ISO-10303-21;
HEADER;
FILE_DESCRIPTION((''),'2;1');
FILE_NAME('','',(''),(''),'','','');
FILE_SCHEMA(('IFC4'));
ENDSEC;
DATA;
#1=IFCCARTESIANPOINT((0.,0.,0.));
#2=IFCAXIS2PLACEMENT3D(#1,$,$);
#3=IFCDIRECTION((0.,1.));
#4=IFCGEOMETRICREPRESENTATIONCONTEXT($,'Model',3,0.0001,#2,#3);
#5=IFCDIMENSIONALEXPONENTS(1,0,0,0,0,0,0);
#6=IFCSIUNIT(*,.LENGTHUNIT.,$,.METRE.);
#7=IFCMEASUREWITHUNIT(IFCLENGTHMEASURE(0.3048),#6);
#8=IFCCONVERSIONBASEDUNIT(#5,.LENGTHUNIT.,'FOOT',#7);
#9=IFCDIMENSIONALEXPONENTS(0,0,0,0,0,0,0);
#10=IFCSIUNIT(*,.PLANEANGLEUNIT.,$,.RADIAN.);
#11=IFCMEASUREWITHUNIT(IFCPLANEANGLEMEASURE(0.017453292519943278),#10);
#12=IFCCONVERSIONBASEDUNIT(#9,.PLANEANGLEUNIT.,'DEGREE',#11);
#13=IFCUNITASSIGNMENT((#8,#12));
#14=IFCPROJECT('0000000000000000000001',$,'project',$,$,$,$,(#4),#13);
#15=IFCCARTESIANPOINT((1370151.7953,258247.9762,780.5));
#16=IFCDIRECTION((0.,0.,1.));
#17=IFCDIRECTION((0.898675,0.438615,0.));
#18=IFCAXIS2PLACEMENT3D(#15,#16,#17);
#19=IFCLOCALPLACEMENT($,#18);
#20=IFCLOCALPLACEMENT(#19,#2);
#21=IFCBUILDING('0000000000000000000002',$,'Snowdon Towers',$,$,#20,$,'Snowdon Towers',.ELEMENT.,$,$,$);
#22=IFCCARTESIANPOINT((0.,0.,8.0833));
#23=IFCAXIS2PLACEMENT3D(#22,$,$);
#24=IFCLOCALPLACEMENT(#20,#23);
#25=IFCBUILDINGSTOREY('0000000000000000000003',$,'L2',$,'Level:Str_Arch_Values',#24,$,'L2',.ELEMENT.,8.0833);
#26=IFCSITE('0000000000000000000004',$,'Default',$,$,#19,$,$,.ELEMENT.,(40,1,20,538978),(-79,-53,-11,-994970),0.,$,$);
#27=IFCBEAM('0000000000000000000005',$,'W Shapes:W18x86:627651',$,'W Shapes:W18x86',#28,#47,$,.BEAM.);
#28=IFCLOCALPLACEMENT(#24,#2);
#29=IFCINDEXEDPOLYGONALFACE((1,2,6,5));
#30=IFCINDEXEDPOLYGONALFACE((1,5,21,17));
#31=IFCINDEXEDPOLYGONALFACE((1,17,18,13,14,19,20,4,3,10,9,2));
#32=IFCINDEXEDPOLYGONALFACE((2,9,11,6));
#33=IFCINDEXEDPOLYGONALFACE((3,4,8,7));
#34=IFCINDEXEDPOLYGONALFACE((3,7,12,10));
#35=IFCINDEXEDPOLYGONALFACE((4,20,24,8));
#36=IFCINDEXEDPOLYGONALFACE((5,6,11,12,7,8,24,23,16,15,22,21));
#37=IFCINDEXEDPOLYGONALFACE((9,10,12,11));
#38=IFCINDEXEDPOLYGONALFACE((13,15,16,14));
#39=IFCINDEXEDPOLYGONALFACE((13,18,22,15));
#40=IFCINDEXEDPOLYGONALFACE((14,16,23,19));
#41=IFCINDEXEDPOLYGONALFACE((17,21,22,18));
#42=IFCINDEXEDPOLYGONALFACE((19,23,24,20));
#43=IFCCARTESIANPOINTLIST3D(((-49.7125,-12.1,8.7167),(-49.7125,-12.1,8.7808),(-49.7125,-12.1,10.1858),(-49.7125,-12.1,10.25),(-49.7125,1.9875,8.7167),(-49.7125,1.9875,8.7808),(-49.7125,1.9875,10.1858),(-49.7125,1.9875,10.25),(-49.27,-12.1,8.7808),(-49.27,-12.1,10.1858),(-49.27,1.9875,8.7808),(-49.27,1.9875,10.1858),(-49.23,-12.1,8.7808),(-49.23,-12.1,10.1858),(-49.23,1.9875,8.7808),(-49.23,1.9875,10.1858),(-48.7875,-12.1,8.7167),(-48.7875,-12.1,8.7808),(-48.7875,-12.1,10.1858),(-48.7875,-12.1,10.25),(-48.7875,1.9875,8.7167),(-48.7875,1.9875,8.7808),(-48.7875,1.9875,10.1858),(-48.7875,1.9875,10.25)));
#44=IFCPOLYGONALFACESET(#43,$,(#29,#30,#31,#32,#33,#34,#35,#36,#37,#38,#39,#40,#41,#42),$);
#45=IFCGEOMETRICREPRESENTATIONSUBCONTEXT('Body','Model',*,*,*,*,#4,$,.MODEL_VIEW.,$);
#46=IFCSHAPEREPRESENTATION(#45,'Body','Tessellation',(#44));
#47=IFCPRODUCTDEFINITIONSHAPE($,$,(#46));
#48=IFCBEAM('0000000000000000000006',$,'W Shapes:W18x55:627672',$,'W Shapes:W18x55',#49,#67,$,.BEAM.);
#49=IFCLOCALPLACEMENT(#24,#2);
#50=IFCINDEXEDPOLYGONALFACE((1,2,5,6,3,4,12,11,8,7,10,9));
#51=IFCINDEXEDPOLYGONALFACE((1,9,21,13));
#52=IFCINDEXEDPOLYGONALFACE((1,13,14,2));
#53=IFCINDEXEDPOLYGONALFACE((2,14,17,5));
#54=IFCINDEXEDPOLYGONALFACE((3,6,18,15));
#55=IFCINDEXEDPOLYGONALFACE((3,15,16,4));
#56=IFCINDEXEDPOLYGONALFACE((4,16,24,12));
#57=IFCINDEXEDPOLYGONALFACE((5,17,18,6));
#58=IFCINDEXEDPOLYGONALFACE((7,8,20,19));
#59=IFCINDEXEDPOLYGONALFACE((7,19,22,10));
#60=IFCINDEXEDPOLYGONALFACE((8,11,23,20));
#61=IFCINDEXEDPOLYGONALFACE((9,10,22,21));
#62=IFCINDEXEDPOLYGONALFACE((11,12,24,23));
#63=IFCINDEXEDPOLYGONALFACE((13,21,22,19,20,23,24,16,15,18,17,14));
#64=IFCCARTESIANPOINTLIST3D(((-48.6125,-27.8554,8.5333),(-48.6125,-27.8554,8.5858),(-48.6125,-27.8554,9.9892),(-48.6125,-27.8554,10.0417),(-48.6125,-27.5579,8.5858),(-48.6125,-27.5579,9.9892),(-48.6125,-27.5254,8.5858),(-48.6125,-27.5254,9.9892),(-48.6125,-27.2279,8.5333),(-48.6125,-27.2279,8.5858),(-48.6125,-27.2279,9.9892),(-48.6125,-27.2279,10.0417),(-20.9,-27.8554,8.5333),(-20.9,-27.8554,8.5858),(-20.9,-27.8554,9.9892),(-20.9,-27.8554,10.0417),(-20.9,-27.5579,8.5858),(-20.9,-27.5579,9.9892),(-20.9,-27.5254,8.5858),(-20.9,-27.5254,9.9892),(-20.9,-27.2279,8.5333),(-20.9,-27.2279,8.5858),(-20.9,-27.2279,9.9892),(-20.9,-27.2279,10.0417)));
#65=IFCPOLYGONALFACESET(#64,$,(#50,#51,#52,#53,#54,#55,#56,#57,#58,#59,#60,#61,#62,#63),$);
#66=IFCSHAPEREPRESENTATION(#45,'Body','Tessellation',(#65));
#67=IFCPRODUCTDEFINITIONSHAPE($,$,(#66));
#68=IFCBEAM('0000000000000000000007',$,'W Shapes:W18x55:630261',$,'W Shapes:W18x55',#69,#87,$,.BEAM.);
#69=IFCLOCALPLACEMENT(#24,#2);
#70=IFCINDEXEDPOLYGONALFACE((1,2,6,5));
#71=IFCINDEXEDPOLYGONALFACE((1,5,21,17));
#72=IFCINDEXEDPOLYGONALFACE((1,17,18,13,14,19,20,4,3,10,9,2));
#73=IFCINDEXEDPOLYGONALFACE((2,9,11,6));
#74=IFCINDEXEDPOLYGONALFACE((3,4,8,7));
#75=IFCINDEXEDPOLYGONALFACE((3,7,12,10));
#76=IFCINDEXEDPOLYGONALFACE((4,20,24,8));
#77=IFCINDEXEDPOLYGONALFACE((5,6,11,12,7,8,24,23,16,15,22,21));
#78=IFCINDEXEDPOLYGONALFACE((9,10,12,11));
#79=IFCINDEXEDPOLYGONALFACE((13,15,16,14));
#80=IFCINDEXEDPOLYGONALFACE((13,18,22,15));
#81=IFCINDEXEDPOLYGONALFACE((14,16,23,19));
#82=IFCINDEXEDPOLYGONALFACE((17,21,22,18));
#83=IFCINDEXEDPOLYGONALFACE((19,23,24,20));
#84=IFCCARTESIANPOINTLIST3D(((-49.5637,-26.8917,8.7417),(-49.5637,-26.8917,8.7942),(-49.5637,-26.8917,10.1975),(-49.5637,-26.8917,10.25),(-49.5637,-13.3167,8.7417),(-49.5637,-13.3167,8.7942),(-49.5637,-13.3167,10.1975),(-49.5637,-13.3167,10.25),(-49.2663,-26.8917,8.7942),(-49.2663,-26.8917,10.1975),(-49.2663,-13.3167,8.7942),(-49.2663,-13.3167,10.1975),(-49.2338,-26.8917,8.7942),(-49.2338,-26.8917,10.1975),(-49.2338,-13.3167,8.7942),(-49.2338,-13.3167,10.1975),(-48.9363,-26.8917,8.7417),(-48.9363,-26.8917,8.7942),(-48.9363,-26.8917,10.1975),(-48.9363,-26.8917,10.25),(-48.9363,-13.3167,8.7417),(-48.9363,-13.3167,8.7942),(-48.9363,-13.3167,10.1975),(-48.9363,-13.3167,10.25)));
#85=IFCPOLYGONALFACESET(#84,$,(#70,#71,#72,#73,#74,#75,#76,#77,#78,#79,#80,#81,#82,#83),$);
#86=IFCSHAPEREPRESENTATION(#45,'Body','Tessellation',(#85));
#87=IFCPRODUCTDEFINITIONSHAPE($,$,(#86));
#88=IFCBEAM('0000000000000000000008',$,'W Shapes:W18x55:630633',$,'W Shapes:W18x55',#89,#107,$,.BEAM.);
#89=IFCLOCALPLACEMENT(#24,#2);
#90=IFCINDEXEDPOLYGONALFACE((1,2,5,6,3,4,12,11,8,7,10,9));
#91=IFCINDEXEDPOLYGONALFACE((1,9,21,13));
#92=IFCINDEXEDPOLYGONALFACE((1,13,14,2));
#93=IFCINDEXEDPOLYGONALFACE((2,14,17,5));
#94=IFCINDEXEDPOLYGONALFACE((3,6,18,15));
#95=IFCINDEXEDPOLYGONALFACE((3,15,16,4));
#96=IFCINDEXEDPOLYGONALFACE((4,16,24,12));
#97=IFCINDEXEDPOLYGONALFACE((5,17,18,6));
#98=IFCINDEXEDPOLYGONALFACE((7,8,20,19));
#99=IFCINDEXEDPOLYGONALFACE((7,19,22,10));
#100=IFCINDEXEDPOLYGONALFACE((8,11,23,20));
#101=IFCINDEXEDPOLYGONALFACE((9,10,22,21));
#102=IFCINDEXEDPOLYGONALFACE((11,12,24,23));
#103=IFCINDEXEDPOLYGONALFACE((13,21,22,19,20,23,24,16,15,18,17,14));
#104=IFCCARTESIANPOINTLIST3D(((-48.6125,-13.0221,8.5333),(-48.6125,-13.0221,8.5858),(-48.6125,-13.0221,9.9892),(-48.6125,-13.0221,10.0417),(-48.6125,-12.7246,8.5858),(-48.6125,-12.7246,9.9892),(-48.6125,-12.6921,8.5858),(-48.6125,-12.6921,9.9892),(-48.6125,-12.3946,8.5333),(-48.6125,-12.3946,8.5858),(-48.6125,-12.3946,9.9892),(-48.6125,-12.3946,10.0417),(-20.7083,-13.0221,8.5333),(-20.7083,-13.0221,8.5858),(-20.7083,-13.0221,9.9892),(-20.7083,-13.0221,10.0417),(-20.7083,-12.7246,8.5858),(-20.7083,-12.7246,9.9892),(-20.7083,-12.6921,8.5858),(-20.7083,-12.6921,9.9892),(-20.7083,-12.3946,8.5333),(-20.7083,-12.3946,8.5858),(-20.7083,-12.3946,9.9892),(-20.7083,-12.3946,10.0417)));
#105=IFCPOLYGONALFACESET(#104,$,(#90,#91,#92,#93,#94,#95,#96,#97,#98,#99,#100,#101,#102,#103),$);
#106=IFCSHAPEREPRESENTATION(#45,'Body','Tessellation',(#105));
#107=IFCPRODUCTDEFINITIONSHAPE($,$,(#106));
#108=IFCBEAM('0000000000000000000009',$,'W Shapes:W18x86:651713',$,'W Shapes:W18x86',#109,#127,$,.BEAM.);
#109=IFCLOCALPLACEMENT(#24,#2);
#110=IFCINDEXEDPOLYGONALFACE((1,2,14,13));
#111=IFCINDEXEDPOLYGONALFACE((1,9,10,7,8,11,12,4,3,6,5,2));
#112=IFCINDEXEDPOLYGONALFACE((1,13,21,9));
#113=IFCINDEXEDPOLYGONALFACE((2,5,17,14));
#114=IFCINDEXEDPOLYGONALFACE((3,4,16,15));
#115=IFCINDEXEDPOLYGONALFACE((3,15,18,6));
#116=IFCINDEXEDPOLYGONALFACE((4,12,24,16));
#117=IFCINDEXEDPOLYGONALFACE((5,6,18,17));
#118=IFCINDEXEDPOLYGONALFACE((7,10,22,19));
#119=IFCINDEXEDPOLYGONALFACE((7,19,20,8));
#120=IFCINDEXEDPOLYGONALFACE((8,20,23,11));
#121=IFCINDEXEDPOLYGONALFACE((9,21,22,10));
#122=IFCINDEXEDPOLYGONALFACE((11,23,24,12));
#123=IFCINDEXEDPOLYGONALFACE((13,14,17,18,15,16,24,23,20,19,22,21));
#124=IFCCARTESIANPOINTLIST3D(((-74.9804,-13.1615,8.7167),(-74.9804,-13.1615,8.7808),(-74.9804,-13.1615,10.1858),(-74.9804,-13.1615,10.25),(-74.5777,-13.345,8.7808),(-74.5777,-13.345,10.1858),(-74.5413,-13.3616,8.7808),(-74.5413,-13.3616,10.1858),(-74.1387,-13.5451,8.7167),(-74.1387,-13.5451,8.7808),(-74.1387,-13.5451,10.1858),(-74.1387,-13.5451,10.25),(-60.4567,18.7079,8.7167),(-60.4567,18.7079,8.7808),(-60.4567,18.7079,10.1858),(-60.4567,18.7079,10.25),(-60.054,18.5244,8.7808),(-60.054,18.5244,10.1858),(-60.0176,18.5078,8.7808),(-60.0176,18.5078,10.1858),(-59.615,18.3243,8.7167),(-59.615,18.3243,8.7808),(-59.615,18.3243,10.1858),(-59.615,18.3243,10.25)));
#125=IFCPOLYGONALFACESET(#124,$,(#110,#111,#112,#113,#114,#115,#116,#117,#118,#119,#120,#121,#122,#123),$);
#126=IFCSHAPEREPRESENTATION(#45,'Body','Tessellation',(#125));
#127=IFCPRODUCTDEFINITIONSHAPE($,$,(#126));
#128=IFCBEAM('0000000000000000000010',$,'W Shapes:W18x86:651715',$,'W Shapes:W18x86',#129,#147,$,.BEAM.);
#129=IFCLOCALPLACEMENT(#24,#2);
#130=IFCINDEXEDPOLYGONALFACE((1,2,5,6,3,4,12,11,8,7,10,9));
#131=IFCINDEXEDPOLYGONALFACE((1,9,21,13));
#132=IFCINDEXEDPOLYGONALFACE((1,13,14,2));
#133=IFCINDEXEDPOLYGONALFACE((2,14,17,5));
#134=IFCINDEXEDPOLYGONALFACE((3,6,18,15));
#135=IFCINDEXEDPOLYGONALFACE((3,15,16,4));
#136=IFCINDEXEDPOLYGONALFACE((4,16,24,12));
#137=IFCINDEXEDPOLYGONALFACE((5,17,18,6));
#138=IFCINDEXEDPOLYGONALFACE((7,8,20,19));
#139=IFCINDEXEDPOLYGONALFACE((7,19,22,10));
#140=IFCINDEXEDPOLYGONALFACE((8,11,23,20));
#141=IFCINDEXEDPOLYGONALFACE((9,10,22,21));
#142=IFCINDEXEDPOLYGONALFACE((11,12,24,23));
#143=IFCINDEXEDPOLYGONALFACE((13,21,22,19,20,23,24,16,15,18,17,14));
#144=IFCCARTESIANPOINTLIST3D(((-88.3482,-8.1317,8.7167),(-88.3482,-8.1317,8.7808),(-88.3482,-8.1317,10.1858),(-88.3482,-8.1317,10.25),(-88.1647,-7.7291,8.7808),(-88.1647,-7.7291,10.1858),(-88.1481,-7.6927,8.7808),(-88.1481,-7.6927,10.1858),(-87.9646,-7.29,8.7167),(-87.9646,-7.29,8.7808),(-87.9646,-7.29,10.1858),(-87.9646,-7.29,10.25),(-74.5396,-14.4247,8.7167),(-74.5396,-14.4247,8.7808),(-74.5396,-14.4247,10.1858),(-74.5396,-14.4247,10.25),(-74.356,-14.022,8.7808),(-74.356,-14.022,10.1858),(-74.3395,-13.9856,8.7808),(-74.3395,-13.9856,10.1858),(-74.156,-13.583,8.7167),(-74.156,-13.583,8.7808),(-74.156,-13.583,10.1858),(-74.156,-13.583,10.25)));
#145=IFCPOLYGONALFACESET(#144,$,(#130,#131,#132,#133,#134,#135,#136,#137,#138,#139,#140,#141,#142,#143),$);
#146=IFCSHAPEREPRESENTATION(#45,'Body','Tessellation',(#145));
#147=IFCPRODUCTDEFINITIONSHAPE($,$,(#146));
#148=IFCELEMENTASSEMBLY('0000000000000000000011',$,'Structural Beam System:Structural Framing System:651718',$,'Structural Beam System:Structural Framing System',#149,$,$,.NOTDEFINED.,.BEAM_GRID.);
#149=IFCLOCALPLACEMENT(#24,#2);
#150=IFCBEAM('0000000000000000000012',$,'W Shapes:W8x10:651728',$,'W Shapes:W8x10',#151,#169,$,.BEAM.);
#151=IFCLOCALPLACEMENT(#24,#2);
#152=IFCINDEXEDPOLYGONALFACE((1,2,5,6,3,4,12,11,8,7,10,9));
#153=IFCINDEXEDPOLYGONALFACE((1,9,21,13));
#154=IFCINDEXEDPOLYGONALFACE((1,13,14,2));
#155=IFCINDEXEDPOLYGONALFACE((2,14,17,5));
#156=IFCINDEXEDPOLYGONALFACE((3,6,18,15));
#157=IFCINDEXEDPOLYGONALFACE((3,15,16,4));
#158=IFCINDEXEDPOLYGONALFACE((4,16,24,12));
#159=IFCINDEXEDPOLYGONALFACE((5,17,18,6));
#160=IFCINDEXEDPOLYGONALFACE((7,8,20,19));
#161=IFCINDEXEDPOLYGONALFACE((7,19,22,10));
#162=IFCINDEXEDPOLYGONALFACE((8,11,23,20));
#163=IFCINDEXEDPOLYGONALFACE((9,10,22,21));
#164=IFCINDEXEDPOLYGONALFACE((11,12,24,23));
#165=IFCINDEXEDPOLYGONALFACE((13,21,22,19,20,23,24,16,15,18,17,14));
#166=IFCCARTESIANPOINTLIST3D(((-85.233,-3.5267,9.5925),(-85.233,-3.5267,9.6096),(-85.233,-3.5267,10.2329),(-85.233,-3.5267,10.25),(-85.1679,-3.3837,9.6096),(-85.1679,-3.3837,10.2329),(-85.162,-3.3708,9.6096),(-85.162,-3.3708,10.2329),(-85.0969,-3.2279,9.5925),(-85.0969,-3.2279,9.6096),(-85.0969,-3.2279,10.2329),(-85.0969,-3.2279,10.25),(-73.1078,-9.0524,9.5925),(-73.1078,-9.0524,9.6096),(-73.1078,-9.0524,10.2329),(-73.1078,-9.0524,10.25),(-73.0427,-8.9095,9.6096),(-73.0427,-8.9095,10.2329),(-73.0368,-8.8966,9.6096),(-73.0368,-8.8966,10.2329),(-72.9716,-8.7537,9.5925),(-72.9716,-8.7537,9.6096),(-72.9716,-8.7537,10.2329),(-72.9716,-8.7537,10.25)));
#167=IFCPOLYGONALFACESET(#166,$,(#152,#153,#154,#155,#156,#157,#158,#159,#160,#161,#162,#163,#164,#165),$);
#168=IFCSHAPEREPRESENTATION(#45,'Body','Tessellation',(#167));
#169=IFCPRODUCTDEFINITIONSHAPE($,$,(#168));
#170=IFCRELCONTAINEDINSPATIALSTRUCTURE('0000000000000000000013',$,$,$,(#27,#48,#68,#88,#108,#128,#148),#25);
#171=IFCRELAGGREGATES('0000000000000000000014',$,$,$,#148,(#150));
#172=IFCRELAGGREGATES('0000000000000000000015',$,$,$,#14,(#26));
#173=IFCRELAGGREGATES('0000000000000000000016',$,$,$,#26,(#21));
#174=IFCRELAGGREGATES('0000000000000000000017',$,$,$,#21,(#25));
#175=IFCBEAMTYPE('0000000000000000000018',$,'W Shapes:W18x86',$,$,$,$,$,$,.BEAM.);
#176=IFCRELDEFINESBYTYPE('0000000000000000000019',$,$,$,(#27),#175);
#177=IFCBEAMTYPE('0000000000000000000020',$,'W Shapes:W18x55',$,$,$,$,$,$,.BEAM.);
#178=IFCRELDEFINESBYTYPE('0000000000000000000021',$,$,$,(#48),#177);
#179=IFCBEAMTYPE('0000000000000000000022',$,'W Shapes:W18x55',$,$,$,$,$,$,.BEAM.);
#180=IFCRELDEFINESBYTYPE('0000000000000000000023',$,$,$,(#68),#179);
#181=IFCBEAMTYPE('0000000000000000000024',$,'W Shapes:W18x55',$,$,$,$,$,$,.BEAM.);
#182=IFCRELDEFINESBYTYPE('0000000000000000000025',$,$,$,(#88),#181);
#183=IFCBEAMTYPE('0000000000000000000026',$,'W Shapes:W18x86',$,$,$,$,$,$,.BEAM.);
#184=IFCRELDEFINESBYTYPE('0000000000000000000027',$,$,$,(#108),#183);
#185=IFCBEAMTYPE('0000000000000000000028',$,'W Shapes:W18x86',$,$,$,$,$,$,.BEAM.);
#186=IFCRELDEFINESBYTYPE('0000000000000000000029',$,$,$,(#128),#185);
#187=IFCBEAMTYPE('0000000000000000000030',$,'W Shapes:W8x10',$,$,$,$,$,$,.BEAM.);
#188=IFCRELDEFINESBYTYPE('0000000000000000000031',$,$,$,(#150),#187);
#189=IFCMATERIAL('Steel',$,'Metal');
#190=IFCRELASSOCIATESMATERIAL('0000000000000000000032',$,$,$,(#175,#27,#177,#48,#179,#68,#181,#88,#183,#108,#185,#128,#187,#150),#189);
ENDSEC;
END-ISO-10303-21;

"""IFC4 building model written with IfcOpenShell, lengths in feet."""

from ifc_helpers import new_model, entity, si_unit, converted_unit, direction, frame, origin, place, context, subcontext, project, spatial, indexed_curve, outline, extrude, source, transform, mapped, material, type_object, type_shapes, element, aggregate, save


model = new_model("IFC4")

# Units and contexts
model_context = context("Model", 3, precision=0.0001, world=origin(), true_north=direction((0.0, 1.0)))
body_context = subcontext(model_context, "Body", "Model", "MODEL_VIEW")
ifc_project = project(units=[converted_unit("LENGTHUNIT", "FOOT", entity("IfcLengthMeasure", 0.3048), si_unit("LENGTHUNIT", "METRE"), dimensions=[1, 0, 0, 0, 0, 0, 0]), converted_unit("PLANEANGLEUNIT", "DEGREE", entity("IfcPlaneAngleMeasure", 0.017453292519943278), si_unit("PLANEANGLEUNIT", "RADIAN"), dimensions=[0, 0, 0, 0, 0, 0, 0])], contexts=[model_context])

# Site, building, storey
site_placement = place(None, frame((1370151.7953, 258247.9762, 780.5), z_axis=(0.0, 0.0, 1.0), x_axis=(0.898675, 0.438615, 0.0)))
site = spatial("IfcSite", under=ifc_project, at=site_placement, Name="Default", CompositionType="ELEMENT", RefLatitude=(40, 1, 20, 538978), RefLongitude=(-79, -53, -11, -994970), RefElevation=0.0)
building_placement = place(site_placement, origin())
building = spatial("IfcBuilding", under=site, at=building_placement, Name="Snowdon Towers", LongName="Snowdon Towers", CompositionType="ELEMENT")
storey_placement = place(building_placement, frame((0.0, 0.0, 8.0833)))
storey = spatial("IfcBuildingStorey", under=building, at=storey_placement, Name="L2", ObjectType="Level:Str_Arch_Values", LongName="L2", CompositionType="ELEMENT", Elevation=8.0833)

# Beams
ifc_material = material(Name="Steel", Category="Metal")
beam_type_1 = type_object("IfcBeamType", Name="W Shapes:W18x86", PredefinedType="BEAM", material=ifc_material)
shared_shape_1 = source(origin(), body_context, "Body", "SweptSolid", [
    extrude(outline(indexed_curve([(-0.4625, -0.7025), (-0.4625, -0.7667), (0.4625, -0.7667), (0.4625, -0.7025), (0.02, -0.7025), (0.02, 0.7025), (0.4625, 0.7025), (0.4625, 0.7667), (-0.4625, 0.7667), (-0.4625, 0.7025), (-0.02, 0.7025), (-0.02, -0.7025), (-0.4625, -0.7025)], self_intersect=False)), frame((-7.0917, 0.0, 0.0), z_axis=(-1.0, 0.0, 0.0), x_axis=(0.0, -1.0, 0.0)), (0.0, 0.0, -1.0), 14.0875),
])
type_shapes(beam_type_1, [shared_shape_1])
beam_1_placement = place(storey_placement, frame((-49.25, -5.1042, 9.4833), z_axis=(0.0, 0.0, 1.0), x_axis=(0.0, -1.0, 0.0)))
element("IfcBeam", 1, at=beam_1_placement, inside=storey, type_object=beam_type_1, material=ifc_material, Name="W Shapes:W18x86:627651", ObjectType="W Shapes:W18x86", PredefinedType="BEAM", context=body_context, shape_type="MappedRepresentation", body=[
    mapped(shared_shape_1, transform((0.0, 0.0, 0.0), scale=1.0)),
])
beam_type_2 = type_object("IfcBeamType", Name="W Shapes:W18x55", PredefinedType="BEAM", material=ifc_material)
shared_shape_2 = source(origin(), body_context, "Body", "SweptSolid", [
    extrude(outline(indexed_curve([(-0.3138, -0.7017), (-0.3138, -0.7542), (0.3138, -0.7542), (0.3138, -0.7017), (0.0162, -0.7017), (0.0162, 0.7017), (0.3138, 0.7017), (0.3138, 0.7542), (-0.3137, 0.7542), (-0.3137, 0.7017), (-0.0163, 0.7017), (-0.0163, -0.7017), (-0.3138, -0.7017)], self_intersect=False)), frame((-13.8625, 0.0, 0.0), z_axis=(-1.0, 0.0, 0.0), x_axis=(0.0, -1.0, 0.0)), (0.0, 0.0, -1.0), 27.7125),
])
type_shapes(beam_type_2, [shared_shape_2])
beam_2_placement = place(storey_placement, frame((-34.75, -27.5417, 9.2875)))
element("IfcBeam", 2, at=beam_2_placement, inside=storey, type_object=beam_type_2, material=ifc_material, Name="W Shapes:W18x55:627672", ObjectType="W Shapes:W18x55", PredefinedType="BEAM", context=body_context, shape_type="MappedRepresentation", body=[
    mapped(shared_shape_2, transform((0.0, 0.0, 0.0), scale=1.0)),
])
beam_type_3 = type_object("IfcBeamType", Name="W Shapes:W18x55", PredefinedType="BEAM", material=ifc_material)
shared_shape_3 = source(origin(), body_context, "Body", "SweptSolid", [
    extrude(outline(indexed_curve([(-0.3138, -0.7017), (-0.3138, -0.7542), (0.3138, -0.7542), (0.3138, -0.7017), (0.0162, -0.7017), (0.0162, 0.7017), (0.3138, 0.7017), (0.3138, 0.7542), (-0.3137, 0.7542), (-0.3137, 0.7017), (-0.0163, 0.7017), (-0.0163, -0.7017), (-0.3138, -0.7017)], self_intersect=False)), frame((-7.0375, 0.0, 0.0), z_axis=(-1.0, 0.0, 0.0), x_axis=(0.0, -1.0, 0.0)), (0.0, 0.0, -1.0), 13.575),
])
type_shapes(beam_type_3, [shared_shape_3])
beam_3_placement = place(storey_placement, frame((-49.25, -20.3542, 9.4958), z_axis=(0.0, 0.0, 1.0), x_axis=(0.0, -1.0, 0.0)))
element("IfcBeam", 3, at=beam_3_placement, inside=storey, type_object=beam_type_3, material=ifc_material, Name="W Shapes:W18x55:630261", ObjectType="W Shapes:W18x55", PredefinedType="BEAM", context=body_context, shape_type="MappedRepresentation", body=[
    mapped(shared_shape_3, transform((0.0, 0.0, 0.0), scale=1.0)),
])
beam_type_4 = type_object("IfcBeamType", Name="W Shapes:W18x55", PredefinedType="BEAM", material=ifc_material)
shared_shape_4 = source(origin(), body_context, "Body", "SweptSolid", [
    extrude(outline(indexed_curve([(-0.3138, -0.7017), (-0.3138, -0.7542), (0.3138, -0.7542), (0.3138, -0.7017), (0.0162, -0.7017), (0.0162, 0.7017), (0.3138, 0.7017), (0.3138, 0.7542), (-0.3137, 0.7542), (-0.3137, 0.7017), (-0.0163, 0.7017), (-0.0163, -0.7017), (-0.3138, -0.7017)], self_intersect=False)), frame((-13.8625, 0.0, 0.0), z_axis=(-1.0, 0.0, 0.0), x_axis=(0.0, -1.0, 0.0)), (0.0, 0.0, -1.0), 27.9042),
])
type_shapes(beam_type_4, [shared_shape_4])
beam_4_placement = place(storey_placement, frame((-34.75, -12.7083, 9.2875)))
element("IfcBeam", 4, at=beam_4_placement, inside=storey, type_object=beam_type_4, material=ifc_material, Name="W Shapes:W18x55:630633", ObjectType="W Shapes:W18x55", PredefinedType="BEAM", context=body_context, shape_type="MappedRepresentation", body=[
    mapped(shared_shape_4, transform((0.0, 0.0, 0.0), scale=1.0)),
])

# Beams
beam_type_5 = type_object("IfcBeamType", Name="W Shapes:W18x86", PredefinedType="BEAM", material=ifc_material)
shared_shape_5 = source(origin(), body_context, "Body", "SweptSolid", [
    extrude(outline(indexed_curve([(-0.4625, -0.7025), (-0.4625, -0.7667), (0.4625, -0.7667), (0.4625, -0.7025), (0.02, -0.7025), (0.02, 0.7025), (0.4625, 0.7025), (0.4625, 0.7667), (-0.4625, 0.7667), (-0.4625, 0.7025), (-0.02, 0.7025), (-0.02, -0.7025), (-0.4625, -0.7025)], self_intersect=False)), frame((-17.6397, 0.0, 0.0), z_axis=(-1.0, 0.0, 0.0), x_axis=(0.0, -1.0, 0.0)), (0.0, 0.0, -1.0), 35.0228),
])
type_shapes(beam_type_5, [shared_shape_5])
beam_5_placement = place(storey_placement, frame((-67.2445, 2.6981, 9.4833), z_axis=(0.0, 0.0, 1.0), x_axis=(0.414693, 0.909961, 0.0)))
element("IfcBeam", 5, at=beam_5_placement, inside=storey, type_object=beam_type_5, material=ifc_material, Name="W Shapes:W18x86:651713", ObjectType="W Shapes:W18x86", PredefinedType="BEAM", context=body_context, shape_type="MappedRepresentation", body=[
    mapped(shared_shape_5, transform((0.0, 0.0, 0.0), scale=1.0)),
])
beam_type_6 = type_object("IfcBeamType", Name="W Shapes:W18x86", PredefinedType="BEAM", material=ifc_material)
shared_shape_6 = source(origin(), body_context, "Body", "SweptSolid", [
    extrude(outline(indexed_curve([(-0.4625, -0.7025), (-0.4625, -0.7667), (0.4625, -0.7667), (0.4625, -0.7025), (0.02, -0.7025), (0.02, 0.7025), (0.4625, 0.7025), (0.4625, 0.7667), (-0.4625, 0.7667), (-0.4625, 0.7025), (-0.02, 0.7025), (-0.02, -0.7025), (-0.4625, -0.7025)], self_intersect=False)), frame((-7.5875, 0.0, 0.0), z_axis=(-1.0, 0.0, 0.0), x_axis=(0.0, -1.0, 0.0)), (0.0, 0.0, -1.0), 15.175),
])
type_shapes(beam_type_6, [shared_shape_6])
beam_6_placement = place(storey_placement, frame((-81.2521, -10.8574, 9.4833), z_axis=(0.0, 0.0, 1.0), x_axis=(0.909961, -0.414693, 0.0)))
element("IfcBeam", 6, at=beam_6_placement, inside=storey, type_object=beam_type_6, material=ifc_material, Name="W Shapes:W18x86:651715", ObjectType="W Shapes:W18x86", PredefinedType="BEAM", context=body_context, shape_type="MappedRepresentation", body=[
    mapped(shared_shape_6, transform((0.0, 0.0, 0.0), scale=1.0)),
])

# Element assembly, beam
assembly_1_placement = place(storey_placement, origin())
assembly_1 = element("IfcElementAssembly", 7, at=assembly_1_placement, inside=storey, Name="Structural Beam System:Structural Framing System:651718", ObjectType="Structural Beam System:Structural Framing System", AssemblyPlace="NOTDEFINED", PredefinedType="BEAM_GRID")
beam_type_7 = type_object("IfcBeamType", Name="W Shapes:W8x10", PredefinedType="BEAM", material=ifc_material)
shared_shape_7 = source(origin(), body_context, "Body", "SweptSolid", [
    extrude(outline(indexed_curve([(-0.1642, -0.3117), (-0.1642, -0.3288), (0.1642, -0.3288), (0.1642, -0.3117), (0.0071, -0.3117), (0.0071, 0.3117), (0.1642, 0.3117), (0.1642, 0.3287), (-0.1642, 0.3287), (-0.1642, 0.3117), (-0.0071, 0.3117), (-0.0071, -0.3117), (-0.1642, -0.3117)], self_intersect=False)), frame((-6.6625, 0.0, 0.0), z_axis=(-1.0, 0.0, 0.0), x_axis=(0.0, -1.0, 0.0)), (0.0, 0.0, -1.0), 13.325),
])
type_shapes(beam_type_7, [shared_shape_7])
beam_7_placement = place(assembly_1_placement, frame((-79.1023, -6.1402, 9.9213), z_axis=(0.0, 0.0, 1.0), x_axis=(0.909961, -0.414693, 0.0)))
beam_7 = element("IfcBeam", 8, at=beam_7_placement, type_object=beam_type_7, material=ifc_material, Name="W Shapes:W8x10:651728", ObjectType="W Shapes:W8x10", PredefinedType="BEAM", context=body_context, shape_type="MappedRepresentation", body=[
    mapped(shared_shape_7, transform((0.0, 0.0, 0.0), scale=1.0)),
])
aggregate(assembly_1, [beam_7])

save(model, "model.ifc")
